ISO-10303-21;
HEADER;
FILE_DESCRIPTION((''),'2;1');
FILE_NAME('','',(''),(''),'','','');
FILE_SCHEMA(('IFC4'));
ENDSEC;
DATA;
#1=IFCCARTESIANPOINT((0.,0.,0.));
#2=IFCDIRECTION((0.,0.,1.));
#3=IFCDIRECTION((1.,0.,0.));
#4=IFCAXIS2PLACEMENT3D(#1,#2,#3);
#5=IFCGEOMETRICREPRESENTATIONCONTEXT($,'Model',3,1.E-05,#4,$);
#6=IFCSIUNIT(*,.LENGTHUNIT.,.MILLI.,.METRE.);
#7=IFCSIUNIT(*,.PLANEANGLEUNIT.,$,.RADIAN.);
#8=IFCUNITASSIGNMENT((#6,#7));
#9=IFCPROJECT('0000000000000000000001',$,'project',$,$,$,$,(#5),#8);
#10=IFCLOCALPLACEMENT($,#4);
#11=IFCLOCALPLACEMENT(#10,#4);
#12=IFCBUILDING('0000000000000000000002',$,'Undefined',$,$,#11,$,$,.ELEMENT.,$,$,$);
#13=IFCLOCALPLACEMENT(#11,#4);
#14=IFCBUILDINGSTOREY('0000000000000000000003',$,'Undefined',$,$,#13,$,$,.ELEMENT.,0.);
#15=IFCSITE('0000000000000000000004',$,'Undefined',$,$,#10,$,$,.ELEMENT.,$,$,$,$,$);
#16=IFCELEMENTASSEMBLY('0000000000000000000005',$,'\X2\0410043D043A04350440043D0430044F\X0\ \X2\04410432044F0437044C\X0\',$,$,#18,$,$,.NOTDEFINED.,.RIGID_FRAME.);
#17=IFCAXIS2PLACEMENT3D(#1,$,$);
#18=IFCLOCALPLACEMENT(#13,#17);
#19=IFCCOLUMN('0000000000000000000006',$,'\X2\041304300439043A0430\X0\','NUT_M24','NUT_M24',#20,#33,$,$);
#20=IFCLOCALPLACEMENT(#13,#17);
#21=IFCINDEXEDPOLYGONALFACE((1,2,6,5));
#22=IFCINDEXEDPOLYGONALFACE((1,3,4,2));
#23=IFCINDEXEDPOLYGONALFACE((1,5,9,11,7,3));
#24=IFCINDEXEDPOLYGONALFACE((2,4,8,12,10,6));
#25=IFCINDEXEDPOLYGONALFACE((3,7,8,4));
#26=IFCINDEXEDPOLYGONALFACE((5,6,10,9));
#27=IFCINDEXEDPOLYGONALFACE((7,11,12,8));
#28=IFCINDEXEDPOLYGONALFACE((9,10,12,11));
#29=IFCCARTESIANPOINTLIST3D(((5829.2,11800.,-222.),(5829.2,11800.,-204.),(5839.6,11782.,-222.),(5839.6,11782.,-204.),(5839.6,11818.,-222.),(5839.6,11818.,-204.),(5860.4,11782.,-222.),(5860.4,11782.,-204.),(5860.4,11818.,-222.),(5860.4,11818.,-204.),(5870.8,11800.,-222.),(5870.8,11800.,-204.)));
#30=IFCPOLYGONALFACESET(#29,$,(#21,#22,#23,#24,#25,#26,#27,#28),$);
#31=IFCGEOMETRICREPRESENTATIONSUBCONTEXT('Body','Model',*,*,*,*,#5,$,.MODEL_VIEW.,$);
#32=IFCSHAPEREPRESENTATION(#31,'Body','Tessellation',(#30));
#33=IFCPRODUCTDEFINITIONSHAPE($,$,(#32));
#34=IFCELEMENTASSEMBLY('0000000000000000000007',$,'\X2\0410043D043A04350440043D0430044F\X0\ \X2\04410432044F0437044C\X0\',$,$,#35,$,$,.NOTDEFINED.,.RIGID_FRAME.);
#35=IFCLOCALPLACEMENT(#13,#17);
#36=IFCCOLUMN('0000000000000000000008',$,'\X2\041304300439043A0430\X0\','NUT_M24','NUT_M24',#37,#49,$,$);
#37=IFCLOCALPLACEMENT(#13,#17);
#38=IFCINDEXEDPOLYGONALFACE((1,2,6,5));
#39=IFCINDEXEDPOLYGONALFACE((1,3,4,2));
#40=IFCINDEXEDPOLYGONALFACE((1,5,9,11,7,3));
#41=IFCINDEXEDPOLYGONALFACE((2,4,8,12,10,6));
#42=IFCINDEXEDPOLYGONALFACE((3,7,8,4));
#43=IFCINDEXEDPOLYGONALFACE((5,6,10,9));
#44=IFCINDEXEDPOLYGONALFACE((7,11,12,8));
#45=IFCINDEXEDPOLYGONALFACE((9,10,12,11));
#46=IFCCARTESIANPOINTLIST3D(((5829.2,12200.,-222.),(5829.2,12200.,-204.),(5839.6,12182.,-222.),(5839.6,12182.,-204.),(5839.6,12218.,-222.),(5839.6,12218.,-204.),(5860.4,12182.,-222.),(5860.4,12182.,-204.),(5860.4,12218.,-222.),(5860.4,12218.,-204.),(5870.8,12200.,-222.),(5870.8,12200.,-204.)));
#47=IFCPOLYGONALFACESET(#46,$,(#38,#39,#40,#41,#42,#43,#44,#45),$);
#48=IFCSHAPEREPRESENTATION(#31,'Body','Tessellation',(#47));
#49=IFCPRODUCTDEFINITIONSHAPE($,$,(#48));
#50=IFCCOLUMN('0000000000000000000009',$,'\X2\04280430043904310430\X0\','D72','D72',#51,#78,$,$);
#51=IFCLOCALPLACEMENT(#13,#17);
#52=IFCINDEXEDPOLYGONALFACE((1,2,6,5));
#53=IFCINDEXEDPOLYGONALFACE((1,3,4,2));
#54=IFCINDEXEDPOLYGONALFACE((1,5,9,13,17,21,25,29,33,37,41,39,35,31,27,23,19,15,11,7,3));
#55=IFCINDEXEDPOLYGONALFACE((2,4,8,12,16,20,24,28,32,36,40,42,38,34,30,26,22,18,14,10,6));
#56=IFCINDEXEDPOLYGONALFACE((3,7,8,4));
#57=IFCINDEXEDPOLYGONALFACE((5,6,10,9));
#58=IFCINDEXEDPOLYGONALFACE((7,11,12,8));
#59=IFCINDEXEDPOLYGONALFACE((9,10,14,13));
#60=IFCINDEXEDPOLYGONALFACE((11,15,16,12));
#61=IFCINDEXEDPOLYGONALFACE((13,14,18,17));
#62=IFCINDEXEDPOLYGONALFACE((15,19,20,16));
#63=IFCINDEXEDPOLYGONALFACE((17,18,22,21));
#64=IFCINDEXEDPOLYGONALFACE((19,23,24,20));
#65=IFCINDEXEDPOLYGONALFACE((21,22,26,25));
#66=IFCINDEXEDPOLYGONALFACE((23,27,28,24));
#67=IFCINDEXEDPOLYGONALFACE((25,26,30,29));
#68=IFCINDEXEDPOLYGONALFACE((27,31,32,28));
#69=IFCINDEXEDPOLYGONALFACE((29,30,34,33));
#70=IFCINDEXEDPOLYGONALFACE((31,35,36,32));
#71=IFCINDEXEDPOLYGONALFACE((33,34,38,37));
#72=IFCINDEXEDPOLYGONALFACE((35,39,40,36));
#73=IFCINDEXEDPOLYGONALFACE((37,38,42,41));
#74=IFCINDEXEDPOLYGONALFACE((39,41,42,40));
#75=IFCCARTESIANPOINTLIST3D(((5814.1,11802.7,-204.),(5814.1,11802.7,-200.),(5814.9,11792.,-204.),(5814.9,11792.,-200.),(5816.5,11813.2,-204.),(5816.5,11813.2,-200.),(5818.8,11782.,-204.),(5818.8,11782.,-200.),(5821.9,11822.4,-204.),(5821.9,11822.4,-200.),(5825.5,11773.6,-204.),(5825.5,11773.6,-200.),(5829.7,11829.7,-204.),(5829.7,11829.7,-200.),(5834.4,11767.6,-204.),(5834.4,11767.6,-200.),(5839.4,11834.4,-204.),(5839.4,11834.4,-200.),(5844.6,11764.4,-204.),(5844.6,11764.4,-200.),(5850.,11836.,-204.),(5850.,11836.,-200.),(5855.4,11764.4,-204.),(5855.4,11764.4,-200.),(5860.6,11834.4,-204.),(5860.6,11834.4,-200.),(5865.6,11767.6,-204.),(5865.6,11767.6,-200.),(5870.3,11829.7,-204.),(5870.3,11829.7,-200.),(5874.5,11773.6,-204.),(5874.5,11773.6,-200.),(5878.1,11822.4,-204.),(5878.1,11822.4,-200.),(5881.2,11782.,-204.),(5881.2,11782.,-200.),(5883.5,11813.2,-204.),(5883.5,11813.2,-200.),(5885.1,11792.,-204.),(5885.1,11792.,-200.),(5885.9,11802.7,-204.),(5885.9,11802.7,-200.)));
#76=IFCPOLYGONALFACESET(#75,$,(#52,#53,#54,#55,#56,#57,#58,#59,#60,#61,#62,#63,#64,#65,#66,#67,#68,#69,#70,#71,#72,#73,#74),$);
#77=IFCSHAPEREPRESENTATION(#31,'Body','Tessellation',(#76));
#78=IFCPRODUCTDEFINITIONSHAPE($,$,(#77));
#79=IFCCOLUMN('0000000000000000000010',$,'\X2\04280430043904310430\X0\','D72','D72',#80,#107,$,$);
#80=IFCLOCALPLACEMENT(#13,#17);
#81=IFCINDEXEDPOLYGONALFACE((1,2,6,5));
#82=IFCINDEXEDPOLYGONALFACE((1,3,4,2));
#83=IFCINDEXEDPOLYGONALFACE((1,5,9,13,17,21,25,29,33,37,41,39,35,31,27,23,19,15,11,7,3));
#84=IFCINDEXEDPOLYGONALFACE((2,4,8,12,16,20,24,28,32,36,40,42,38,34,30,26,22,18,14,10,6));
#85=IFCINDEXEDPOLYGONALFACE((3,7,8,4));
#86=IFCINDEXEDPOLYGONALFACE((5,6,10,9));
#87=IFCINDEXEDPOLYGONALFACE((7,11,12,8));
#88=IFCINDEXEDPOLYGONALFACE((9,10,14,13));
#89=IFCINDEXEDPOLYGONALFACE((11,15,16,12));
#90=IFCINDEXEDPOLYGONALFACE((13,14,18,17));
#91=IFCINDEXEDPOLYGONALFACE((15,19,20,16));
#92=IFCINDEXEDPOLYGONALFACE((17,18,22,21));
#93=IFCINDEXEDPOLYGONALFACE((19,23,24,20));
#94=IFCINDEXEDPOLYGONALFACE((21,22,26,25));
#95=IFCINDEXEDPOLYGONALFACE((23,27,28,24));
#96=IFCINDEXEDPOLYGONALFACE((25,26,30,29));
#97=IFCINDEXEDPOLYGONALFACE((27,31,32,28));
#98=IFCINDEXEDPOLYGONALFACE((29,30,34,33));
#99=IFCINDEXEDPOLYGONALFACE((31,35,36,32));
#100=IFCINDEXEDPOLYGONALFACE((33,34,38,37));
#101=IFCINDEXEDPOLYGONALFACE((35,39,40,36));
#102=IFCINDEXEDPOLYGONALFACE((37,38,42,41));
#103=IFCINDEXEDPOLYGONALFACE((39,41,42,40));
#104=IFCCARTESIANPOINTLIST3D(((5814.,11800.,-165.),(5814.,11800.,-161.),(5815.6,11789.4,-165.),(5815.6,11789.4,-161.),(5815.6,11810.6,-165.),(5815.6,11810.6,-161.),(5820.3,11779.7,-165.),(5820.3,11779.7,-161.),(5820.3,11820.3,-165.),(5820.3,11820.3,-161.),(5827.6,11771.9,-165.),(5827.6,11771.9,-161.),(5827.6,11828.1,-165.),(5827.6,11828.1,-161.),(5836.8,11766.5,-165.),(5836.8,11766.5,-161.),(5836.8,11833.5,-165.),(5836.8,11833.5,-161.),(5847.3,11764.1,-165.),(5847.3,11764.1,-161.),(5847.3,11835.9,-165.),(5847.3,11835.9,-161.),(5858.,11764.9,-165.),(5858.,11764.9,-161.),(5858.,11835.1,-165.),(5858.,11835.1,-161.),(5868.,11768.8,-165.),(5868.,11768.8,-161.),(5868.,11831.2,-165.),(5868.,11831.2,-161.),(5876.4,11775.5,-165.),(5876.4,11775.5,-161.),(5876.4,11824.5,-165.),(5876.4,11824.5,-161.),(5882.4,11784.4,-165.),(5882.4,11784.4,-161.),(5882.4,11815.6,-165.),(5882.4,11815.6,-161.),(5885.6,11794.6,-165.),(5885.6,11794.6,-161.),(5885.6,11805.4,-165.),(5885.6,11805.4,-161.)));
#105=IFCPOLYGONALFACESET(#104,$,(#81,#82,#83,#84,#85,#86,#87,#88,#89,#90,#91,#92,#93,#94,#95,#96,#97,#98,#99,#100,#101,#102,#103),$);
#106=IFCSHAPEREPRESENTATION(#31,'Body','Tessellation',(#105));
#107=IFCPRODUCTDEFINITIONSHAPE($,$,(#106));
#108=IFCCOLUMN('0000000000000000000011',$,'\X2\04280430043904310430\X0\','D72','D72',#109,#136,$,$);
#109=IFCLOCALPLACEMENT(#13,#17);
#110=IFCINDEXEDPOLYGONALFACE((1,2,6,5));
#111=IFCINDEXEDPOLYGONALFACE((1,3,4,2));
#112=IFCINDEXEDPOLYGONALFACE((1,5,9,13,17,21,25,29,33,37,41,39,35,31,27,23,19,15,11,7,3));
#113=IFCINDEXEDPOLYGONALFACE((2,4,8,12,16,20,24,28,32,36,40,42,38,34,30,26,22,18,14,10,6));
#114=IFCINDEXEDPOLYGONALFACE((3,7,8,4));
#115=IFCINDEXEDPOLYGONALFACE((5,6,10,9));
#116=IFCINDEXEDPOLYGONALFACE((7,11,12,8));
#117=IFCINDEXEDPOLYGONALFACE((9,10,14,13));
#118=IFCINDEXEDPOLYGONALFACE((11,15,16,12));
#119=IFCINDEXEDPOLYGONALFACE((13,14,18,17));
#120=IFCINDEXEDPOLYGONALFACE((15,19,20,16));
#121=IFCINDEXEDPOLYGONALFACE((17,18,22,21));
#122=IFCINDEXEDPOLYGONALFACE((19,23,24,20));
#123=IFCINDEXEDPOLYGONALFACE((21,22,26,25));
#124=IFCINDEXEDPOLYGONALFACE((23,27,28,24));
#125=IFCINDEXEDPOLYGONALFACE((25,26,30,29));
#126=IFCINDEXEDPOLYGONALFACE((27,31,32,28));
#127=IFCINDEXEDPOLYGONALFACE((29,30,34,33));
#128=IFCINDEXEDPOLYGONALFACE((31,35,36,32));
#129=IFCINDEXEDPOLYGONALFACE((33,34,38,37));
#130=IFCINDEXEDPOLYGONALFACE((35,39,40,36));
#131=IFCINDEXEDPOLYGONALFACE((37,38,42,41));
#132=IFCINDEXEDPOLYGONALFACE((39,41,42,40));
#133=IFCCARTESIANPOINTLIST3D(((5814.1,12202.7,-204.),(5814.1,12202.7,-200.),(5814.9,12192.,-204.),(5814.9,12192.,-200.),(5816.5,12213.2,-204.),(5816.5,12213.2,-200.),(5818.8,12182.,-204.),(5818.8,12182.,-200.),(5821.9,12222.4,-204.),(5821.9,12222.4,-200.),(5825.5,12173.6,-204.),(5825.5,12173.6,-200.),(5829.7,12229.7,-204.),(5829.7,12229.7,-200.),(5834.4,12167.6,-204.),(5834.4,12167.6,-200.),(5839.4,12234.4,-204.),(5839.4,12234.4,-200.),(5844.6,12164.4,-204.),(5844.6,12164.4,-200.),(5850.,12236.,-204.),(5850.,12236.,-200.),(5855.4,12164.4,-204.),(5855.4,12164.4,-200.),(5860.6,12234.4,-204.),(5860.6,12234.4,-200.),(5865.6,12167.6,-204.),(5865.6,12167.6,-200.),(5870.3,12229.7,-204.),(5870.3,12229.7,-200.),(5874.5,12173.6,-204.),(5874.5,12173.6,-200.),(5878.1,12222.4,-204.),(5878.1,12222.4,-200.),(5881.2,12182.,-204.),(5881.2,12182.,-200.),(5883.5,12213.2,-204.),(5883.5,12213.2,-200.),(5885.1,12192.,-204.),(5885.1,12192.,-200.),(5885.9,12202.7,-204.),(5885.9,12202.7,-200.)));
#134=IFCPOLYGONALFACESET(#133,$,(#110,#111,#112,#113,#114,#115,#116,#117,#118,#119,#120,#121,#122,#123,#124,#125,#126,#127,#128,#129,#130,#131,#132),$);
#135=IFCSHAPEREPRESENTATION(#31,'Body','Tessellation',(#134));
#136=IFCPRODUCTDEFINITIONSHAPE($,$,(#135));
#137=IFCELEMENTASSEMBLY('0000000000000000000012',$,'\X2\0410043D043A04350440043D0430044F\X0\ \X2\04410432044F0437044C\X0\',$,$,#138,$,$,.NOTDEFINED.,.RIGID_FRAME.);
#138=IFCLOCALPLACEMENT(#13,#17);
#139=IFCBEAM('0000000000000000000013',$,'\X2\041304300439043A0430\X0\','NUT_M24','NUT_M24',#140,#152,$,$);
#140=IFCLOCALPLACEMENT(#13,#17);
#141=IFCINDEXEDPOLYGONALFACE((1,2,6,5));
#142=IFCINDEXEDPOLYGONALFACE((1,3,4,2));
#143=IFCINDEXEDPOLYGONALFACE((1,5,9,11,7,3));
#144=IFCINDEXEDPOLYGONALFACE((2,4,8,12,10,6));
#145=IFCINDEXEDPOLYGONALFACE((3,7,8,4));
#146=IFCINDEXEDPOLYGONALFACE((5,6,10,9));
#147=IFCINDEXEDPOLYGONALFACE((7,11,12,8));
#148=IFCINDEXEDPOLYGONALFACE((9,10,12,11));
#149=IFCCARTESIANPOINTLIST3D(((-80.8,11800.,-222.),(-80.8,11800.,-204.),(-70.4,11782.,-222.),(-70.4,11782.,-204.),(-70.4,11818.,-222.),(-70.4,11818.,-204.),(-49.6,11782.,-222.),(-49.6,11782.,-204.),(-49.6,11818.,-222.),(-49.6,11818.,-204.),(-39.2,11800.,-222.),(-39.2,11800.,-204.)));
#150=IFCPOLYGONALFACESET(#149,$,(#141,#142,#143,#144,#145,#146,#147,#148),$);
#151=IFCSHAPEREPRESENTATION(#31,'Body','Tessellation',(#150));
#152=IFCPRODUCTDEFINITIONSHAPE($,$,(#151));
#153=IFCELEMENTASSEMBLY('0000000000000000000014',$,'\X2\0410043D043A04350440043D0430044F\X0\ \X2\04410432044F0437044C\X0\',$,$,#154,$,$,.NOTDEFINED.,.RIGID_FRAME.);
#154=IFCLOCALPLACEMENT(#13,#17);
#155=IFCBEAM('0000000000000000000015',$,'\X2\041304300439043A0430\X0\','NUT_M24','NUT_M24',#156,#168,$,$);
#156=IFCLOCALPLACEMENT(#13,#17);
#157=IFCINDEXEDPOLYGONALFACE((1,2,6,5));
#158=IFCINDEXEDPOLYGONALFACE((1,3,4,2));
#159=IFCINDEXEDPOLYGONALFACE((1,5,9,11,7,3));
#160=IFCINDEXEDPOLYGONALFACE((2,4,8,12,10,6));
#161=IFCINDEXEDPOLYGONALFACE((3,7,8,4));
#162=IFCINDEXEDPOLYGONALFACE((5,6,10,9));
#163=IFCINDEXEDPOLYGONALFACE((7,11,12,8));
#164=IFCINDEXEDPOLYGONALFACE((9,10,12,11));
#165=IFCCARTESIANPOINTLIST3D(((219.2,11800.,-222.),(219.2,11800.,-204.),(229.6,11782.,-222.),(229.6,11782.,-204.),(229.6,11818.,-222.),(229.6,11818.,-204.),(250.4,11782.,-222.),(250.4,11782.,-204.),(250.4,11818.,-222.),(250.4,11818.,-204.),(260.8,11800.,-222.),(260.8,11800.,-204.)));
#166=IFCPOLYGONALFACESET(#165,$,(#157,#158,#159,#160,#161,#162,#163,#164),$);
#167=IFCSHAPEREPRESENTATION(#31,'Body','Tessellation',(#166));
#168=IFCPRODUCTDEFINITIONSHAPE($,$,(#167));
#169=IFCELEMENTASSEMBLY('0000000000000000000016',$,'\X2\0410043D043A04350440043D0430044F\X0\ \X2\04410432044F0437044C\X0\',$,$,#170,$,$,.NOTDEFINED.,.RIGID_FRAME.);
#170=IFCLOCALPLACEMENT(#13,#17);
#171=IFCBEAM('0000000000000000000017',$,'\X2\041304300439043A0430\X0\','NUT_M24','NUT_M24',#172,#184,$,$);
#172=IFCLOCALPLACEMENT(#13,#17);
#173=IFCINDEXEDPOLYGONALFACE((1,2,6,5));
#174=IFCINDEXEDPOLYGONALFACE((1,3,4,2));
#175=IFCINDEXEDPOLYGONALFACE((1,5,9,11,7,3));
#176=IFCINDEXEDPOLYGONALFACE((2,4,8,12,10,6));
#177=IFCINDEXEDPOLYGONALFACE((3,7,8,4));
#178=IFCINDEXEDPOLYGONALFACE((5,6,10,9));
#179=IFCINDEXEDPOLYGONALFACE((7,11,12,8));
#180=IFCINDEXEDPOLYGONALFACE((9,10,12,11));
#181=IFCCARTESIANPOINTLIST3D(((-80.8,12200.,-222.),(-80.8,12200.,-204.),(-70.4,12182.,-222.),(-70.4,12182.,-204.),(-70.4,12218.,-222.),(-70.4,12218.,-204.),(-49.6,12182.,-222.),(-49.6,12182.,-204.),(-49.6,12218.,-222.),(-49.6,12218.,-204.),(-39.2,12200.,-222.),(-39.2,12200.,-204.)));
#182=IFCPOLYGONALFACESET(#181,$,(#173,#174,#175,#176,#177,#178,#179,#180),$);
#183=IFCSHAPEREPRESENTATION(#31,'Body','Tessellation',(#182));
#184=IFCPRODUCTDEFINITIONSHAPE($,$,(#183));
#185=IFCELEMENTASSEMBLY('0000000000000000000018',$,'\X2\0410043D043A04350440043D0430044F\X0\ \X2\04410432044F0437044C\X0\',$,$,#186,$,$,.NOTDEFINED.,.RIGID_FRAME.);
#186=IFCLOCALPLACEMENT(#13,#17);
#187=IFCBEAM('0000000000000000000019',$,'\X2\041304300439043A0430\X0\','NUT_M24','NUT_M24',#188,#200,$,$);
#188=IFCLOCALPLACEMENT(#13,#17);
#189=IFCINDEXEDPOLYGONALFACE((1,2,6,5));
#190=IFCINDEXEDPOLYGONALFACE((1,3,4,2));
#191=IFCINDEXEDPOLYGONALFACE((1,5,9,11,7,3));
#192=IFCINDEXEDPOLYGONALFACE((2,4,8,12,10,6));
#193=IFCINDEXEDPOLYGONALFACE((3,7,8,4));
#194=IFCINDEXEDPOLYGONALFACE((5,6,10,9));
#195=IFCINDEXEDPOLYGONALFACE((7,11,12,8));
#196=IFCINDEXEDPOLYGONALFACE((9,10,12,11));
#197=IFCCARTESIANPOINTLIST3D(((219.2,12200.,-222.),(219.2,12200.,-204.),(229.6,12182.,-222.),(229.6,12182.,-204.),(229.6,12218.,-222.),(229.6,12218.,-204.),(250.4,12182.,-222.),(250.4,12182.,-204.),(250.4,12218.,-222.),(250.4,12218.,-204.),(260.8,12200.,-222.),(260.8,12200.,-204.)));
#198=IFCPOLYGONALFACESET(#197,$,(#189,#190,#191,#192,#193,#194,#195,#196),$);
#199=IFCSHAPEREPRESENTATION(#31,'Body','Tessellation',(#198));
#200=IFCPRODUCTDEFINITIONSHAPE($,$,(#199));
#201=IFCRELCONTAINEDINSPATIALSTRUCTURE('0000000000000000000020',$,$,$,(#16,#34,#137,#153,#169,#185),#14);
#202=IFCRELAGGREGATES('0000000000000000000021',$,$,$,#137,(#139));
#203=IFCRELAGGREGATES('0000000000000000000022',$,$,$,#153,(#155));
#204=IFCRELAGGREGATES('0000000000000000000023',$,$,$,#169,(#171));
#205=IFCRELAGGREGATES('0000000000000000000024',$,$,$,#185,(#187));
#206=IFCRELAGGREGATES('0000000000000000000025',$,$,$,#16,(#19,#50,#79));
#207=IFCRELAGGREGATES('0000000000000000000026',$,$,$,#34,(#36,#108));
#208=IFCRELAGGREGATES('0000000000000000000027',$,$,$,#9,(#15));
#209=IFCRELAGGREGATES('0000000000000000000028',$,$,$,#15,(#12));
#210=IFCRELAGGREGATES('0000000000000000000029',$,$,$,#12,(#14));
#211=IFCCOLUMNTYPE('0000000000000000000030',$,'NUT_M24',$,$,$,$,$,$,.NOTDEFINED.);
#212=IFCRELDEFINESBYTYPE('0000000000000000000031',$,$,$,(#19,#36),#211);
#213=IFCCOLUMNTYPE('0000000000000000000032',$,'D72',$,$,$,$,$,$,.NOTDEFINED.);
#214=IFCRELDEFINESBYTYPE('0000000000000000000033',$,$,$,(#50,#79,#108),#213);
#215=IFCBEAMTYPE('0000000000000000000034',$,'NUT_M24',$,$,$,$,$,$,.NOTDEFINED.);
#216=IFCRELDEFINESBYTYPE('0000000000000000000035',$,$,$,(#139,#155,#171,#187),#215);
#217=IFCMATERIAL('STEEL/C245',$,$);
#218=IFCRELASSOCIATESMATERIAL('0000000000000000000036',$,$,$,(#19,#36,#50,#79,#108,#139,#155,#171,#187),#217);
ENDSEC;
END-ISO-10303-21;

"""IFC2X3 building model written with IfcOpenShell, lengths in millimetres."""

from ifc_helpers import new_model, si_unit, frame, origin_with_axes, origin_2d_with_axis, place, context, subcontext, project, spatial, polyline, circle, outline, extrude, material, type_object, element, aggregate, save


model = new_model("IFC2X3")

# Units and contexts
model_context = context("Model", 3, precision=1e-05, world=origin_with_axes())
body_context = subcontext(model_context, "Body", "Model", "MODEL_VIEW")
ifc_project = project(units=[si_unit("LENGTHUNIT", "METRE", prefix="MILLI"), si_unit("PLANEANGLEUNIT", "RADIAN")], contexts=[model_context])

# Site, building, storey
site_placement = place(None, origin_with_axes())
site = spatial("IfcSite", under=ifc_project, at=site_placement, Name="Undefined", CompositionType="ELEMENT")
building_placement = place(site_placement, origin_with_axes())
building = spatial("IfcBuilding", under=site, at=building_placement, Name="Undefined", CompositionType="ELEMENT")
storey_placement = place(building_placement, origin_with_axes())
storey = spatial("IfcBuildingStorey", under=building, at=storey_placement, Name="Undefined", CompositionType="ELEMENT", Elevation=0.0)

# Element assemblies, columns
assembly_1_placement = place(storey_placement, origin_with_axes())
assembly_1 = element("IfcElementAssembly", 1, at=assembly_1_placement, inside=storey, Name="Анкерная связь", AssemblyPlace="NOTDEFINED", PredefinedType="RIGID_FRAME")
ifc_material_1 = material(Name="STEEL/C245")
column_type_1 = type_object("IfcColumnType", Name="NUT_M24", PredefinedType="NOTDEFINED")
column_1_placement = place(assembly_1_placement, frame((5850.0, 11800.0, -204.0), z_axis=(0.0, 0.0, -1.0), x_axis=(0.0, -1.0, 0.0)))
column_1 = element("IfcColumn", 2, at=column_1_placement, type_object=column_type_1, material=ifc_material_1, Name="Гайка", Description="NUT_M24", ObjectType="NUT_M24", context=body_context, shape_type="SweptSolid", body=[
    extrude(outline(polyline([(-10.4, 18.0), (10.4, 18.0), (20.8, 0.0), (10.4, -18.0), (-10.4, -18.0), (-20.8, 0.0), (-10.4, 18.0)])), frame((0.0, 0.0, 18.0), z_axis=(0.0, 0.0, -1.0), x_axis=(0.0, 1.0, 0.0)), (0.0, 0.0, 1.0), 18.0),
])
assembly_2_placement = place(storey_placement, origin_with_axes())
assembly_2 = element("IfcElementAssembly", 3, at=assembly_2_placement, inside=storey, Name="Анкерная связь", AssemblyPlace="NOTDEFINED", PredefinedType="RIGID_FRAME")
column_2_placement = place(assembly_2_placement, frame((5850.0, 12200.0, -204.0), z_axis=(0.0, 0.0, -1.0), x_axis=(0.0, -1.0, 0.0)))
column_2 = element("IfcColumn", 4, at=column_2_placement, type_object=column_type_1, material=ifc_material_1, Name="Гайка", Description="NUT_M24", ObjectType="NUT_M24", context=body_context, shape_type="SweptSolid", body=[
    extrude(outline(polyline([(-10.4, 18.0), (10.4, 18.0), (20.8, 0.0), (10.4, -18.0), (-10.4, -18.0), (-20.8, 0.0), (-10.4, 18.0)])), frame((0.0, 0.0, 18.0), z_axis=(0.0, 0.0, -1.0), x_axis=(0.0, 1.0, 0.0)), (0.0, 0.0, 1.0), 18.0),
])

# Columns
column_type_2 = type_object("IfcColumnType", Name="D72", PredefinedType="NOTDEFINED")
column_3_placement = place(assembly_1_placement, frame((5850.0, 11800.0, -200.0), z_axis=(0.0, 0.0, -1.0), x_axis=(-1.0, 0.0, 0.0)))
column_3 = element("IfcColumn", 5, at=column_3_placement, type_object=column_type_2, material=ifc_material_1, Name="Шайба", Description="D72", ObjectType="D72", context=body_context, shape_type="SweptSolid", body=[
    extrude(circle(Radius=36.0, at=origin_2d_with_axis()), frame((0.0, 0.0, 4.0), z_axis=(0.0, 0.0, -1.0), x_axis=(0.0, 1.0, 0.0)), (0.0, 0.0, 1.0), 4.0),
])
column_4_placement = place(assembly_1_placement, frame((5850.0, 11800.0, -161.0), z_axis=(0.0, 0.0, -1.0), x_axis=(0.0, -1.0, 0.0)))
column_4 = element("IfcColumn", 6, at=column_4_placement, type_object=column_type_2, material=ifc_material_1, Name="Шайба", Description="D72", ObjectType="D72", context=body_context, shape_type="SweptSolid", body=[
    extrude(circle(Radius=36.0, at=origin_2d_with_axis()), frame((0.0, 0.0, 4.0), z_axis=(0.0, 0.0, -1.0), x_axis=(0.0, 1.0, 0.0)), (0.0, 0.0, 1.0), 4.0),
])
column_5_placement = place(assembly_2_placement, frame((5850.0, 12200.0, -200.0), z_axis=(0.0, 0.0, -1.0), x_axis=(-1.0, 0.0, 0.0)))
column_5 = element("IfcColumn", 7, at=column_5_placement, type_object=column_type_2, material=ifc_material_1, Name="Шайба", Description="D72", ObjectType="D72", context=body_context, shape_type="SweptSolid", body=[
    extrude(circle(Radius=36.0, at=origin_2d_with_axis()), frame((0.0, 0.0, 4.0), z_axis=(0.0, 0.0, -1.0), x_axis=(0.0, 1.0, 0.0)), (0.0, 0.0, 1.0), 4.0),
])

# Element assemblies, beams
assembly_3_placement = place(storey_placement, origin_with_axes())
assembly_3 = element("IfcElementAssembly", 8, at=assembly_3_placement, inside=storey, Name="Анкерная связь", AssemblyPlace="NOTDEFINED", PredefinedType="RIGID_FRAME")
beam_type_1 = type_object("IfcBeamType", Name="NUT_M24", PredefinedType="NOTDEFINED")
beam_1_placement = place(assembly_3_placement, frame((-60.0, 11800.0, -204.0), z_axis=(0.0, -1.0, 0.0), x_axis=(0.0, 0.0, -1.0)))
beam_1 = element("IfcBeam", 9, at=beam_1_placement, type_object=beam_type_1, material=ifc_material_1, Name="Гайка", Description="NUT_M24", ObjectType="NUT_M24", context=body_context, shape_type="SweptSolid", body=[
    extrude(outline(polyline([(-10.4, 18.0), (10.4, 18.0), (20.8, 0.0), (10.4, -18.0), (-10.4, -18.0), (-20.8, 0.0), (-10.4, 18.0)])), frame((18.0, 0.0, 0.0), z_axis=(-1.0, 0.0, 0.0), x_axis=(0.0, -1.0, 0.0)), (0.0, 0.0, 1.0), 18.0),
])
assembly_4_placement = place(storey_placement, origin_with_axes())
assembly_4 = element("IfcElementAssembly", 10, at=assembly_4_placement, inside=storey, Name="Анкерная связь", AssemblyPlace="NOTDEFINED", PredefinedType="RIGID_FRAME")
beam_2_placement = place(assembly_4_placement, frame((240.0, 11800.0, -204.0), z_axis=(0.0, 1.0, 0.0), x_axis=(0.0, 0.0, -1.0)))
beam_2 = element("IfcBeam", 11, at=beam_2_placement, type_object=beam_type_1, material=ifc_material_1, Name="Гайка", Description="NUT_M24", ObjectType="NUT_M24", context=body_context, shape_type="SweptSolid", body=[
    extrude(outline(polyline([(-10.4, 18.0), (10.4, 18.0), (20.8, 0.0), (10.4, -18.0), (-10.4, -18.0), (-20.8, 0.0), (-10.4, 18.0)])), frame((18.0, 0.0, 0.0), z_axis=(-1.0, 0.0, 0.0), x_axis=(0.0, -1.0, 0.0)), (0.0, 0.0, 1.0), 18.0),
])
assembly_5_placement = place(storey_placement, origin_with_axes())
assembly_5 = element("IfcElementAssembly", 12, at=assembly_5_placement, inside=storey, Name="Анкерная связь", AssemblyPlace="NOTDEFINED", PredefinedType="RIGID_FRAME")
beam_3_placement = place(assembly_5_placement, frame((-60.0, 12200.0, -204.0), z_axis=(0.0, -1.0, 0.0), x_axis=(0.0, 0.0, -1.0)))
beam_3 = element("IfcBeam", 13, at=beam_3_placement, type_object=beam_type_1, material=ifc_material_1, Name="Гайка", Description="NUT_M24", ObjectType="NUT_M24", context=body_context, shape_type="SweptSolid", body=[
    extrude(outline(polyline([(-10.4, 18.0), (10.4, 18.0), (20.8, 0.0), (10.4, -18.0), (-10.4, -18.0), (-20.8, 0.0), (-10.4, 18.0)])), frame((18.0, 0.0, 0.0), z_axis=(-1.0, 0.0, 0.0), x_axis=(0.0, -1.0, 0.0)), (0.0, 0.0, 1.0), 18.0),
])
assembly_6_placement = place(storey_placement, origin_with_axes())
assembly_6 = element("IfcElementAssembly", 14, at=assembly_6_placement, inside=storey, Name="Анкерная связь", AssemblyPlace="NOTDEFINED", PredefinedType="RIGID_FRAME")
beam_4_placement = place(assembly_6_placement, frame((240.0, 12200.0, -204.0), z_axis=(0.0, 1.0, 0.0), x_axis=(0.0, 0.0, -1.0)))
beam_4 = element("IfcBeam", 15, at=beam_4_placement, type_object=beam_type_1, material=ifc_material_1, Name="Гайка", Description="NUT_M24", ObjectType="NUT_M24", context=body_context, shape_type="SweptSolid", body=[
    extrude(outline(polyline([(-10.4, 18.0), (10.4, 18.0), (20.8, 0.0), (10.4, -18.0), (-10.4, -18.0), (-20.8, 0.0), (-10.4, 18.0)])), frame((18.0, 0.0, 0.0), z_axis=(-1.0, 0.0, 0.0), x_axis=(0.0, -1.0, 0.0)), (0.0, 0.0, 1.0), 18.0),
])

aggregate(assembly_3, [beam_1])
aggregate(assembly_4, [beam_2])
aggregate(assembly_5, [beam_3])
aggregate(assembly_6, [beam_4])
aggregate(assembly_1, [column_1, column_3, column_4])
aggregate(assembly_2, [column_2, column_5])

save(model, "model.ifc")
